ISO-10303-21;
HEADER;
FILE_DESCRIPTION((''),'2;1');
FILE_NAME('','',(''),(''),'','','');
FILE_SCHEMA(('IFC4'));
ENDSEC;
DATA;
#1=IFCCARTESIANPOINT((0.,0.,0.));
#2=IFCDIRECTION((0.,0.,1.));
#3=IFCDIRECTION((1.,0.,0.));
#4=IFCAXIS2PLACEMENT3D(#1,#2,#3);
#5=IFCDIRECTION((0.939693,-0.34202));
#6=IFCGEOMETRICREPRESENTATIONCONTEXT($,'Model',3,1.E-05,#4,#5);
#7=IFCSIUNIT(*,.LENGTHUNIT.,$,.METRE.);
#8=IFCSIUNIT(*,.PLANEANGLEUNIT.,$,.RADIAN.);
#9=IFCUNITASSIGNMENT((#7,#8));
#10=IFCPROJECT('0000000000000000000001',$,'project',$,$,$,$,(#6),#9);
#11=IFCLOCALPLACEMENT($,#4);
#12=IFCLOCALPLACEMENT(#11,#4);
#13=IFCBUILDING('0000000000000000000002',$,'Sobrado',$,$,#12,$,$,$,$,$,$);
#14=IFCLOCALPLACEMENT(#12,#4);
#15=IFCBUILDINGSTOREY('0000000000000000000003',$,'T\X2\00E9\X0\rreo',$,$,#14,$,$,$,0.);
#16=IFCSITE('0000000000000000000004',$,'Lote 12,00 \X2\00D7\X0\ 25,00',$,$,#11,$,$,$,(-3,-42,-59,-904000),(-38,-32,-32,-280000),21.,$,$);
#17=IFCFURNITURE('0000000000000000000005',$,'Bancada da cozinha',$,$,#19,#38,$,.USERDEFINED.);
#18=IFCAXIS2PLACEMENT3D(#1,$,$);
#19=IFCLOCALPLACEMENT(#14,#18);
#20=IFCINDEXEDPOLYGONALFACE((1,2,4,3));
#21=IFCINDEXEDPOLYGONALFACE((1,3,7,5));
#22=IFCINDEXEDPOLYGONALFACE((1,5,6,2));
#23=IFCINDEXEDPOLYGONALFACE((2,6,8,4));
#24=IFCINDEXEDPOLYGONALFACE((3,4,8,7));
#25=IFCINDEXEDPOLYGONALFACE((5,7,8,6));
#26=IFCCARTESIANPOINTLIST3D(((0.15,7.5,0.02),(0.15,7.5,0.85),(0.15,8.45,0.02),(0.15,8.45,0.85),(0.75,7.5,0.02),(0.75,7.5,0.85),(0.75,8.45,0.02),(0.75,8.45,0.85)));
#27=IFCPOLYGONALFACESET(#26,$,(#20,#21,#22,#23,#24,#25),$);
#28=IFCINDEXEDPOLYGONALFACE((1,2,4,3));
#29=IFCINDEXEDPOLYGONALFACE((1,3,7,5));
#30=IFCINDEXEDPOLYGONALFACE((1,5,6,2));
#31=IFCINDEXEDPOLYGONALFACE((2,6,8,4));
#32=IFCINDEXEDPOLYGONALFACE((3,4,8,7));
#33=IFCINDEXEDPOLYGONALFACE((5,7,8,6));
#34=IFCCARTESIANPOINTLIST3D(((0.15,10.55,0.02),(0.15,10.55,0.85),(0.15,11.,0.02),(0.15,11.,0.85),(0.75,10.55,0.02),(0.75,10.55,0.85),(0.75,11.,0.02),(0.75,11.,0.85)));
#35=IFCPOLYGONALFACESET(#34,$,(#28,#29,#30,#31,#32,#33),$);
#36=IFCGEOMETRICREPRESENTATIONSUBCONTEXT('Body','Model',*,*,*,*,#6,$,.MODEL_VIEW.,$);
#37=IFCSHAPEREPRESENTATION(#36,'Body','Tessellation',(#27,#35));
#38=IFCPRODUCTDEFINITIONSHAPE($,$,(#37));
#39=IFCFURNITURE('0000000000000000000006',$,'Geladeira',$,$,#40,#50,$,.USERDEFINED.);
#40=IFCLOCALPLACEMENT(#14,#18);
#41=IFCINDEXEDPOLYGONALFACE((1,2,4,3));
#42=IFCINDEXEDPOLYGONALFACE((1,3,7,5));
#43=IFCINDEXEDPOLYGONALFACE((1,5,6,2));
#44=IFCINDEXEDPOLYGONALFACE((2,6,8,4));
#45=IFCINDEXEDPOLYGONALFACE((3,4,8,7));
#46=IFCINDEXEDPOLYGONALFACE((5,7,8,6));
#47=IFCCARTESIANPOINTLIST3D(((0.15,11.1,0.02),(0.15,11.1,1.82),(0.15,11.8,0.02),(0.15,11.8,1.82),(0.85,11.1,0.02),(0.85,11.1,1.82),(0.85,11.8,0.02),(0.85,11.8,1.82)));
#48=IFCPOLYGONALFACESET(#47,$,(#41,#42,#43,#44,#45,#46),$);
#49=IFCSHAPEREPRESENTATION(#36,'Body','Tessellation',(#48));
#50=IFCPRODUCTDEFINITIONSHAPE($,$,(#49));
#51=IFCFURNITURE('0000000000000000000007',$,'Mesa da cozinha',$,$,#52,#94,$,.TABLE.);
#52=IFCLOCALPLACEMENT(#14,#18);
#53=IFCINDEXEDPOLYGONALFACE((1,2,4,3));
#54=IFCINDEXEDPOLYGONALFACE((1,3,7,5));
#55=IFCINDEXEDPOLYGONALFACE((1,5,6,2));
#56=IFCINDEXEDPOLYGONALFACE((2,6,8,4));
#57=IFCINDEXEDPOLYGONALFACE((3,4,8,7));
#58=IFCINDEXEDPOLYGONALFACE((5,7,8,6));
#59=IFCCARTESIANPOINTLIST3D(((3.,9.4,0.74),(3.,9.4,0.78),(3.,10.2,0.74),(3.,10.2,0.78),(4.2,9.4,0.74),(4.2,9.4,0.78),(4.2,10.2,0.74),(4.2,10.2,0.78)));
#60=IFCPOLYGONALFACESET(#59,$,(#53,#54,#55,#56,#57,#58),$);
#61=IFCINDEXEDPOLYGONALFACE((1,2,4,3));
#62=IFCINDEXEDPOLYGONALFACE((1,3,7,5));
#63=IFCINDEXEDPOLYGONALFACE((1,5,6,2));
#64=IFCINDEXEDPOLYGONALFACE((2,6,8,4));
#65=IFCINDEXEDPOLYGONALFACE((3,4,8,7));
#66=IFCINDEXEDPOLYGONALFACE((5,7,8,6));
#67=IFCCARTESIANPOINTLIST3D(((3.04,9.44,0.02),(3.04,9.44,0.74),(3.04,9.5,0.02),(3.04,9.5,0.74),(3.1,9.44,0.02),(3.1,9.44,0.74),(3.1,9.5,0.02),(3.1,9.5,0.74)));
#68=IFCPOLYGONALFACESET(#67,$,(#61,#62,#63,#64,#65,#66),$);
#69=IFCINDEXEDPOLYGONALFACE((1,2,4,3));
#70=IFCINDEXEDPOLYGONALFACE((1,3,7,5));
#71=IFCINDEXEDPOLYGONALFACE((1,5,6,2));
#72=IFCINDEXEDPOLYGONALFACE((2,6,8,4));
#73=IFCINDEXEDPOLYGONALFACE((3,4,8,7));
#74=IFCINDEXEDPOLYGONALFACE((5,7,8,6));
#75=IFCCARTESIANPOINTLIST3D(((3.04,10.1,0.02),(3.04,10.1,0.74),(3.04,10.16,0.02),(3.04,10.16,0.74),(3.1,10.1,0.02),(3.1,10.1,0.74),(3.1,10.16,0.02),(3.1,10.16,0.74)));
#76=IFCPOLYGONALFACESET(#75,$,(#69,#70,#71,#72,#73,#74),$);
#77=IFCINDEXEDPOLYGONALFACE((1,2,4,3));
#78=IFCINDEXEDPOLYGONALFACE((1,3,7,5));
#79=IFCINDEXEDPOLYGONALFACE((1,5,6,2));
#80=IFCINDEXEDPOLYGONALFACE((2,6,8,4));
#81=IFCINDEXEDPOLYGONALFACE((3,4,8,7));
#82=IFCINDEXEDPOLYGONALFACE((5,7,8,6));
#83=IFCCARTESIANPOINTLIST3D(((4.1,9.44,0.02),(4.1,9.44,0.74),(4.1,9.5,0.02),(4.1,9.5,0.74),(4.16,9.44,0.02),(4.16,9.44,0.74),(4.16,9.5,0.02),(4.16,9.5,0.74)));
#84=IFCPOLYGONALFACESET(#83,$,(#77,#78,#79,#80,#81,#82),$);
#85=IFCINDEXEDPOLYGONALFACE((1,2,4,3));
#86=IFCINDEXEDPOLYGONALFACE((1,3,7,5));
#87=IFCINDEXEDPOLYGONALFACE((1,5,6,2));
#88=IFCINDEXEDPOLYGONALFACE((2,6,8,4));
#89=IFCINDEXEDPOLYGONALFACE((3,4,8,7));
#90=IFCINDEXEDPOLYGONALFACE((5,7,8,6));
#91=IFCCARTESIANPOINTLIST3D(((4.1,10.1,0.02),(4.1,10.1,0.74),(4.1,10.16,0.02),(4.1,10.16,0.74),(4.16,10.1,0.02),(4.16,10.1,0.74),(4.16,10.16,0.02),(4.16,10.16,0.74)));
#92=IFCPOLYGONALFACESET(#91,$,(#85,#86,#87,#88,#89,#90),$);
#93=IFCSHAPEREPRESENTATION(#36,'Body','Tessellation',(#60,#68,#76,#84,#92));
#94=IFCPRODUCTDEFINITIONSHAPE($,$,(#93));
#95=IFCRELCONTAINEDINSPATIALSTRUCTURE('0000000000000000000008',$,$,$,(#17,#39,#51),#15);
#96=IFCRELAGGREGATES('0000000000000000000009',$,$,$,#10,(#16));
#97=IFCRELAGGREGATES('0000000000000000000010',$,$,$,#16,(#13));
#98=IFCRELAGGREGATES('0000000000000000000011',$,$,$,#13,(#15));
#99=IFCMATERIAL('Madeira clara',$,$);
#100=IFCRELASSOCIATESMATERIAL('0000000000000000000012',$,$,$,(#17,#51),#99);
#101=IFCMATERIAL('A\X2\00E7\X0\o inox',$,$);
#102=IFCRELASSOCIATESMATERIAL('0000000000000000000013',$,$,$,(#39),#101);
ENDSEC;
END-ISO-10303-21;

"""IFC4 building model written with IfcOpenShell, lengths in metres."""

from ifc_helpers import new_model, si_unit, direction, frame, origin_with_axes, place, context, subcontext, project, spatial, line, indexed_curve, outline, extrude, material, element, save


model = new_model("IFC4")

# Units and contexts
model_context = context("Model", 3, precision=1e-05, world=origin_with_axes(), true_north=direction((0.939693, -0.34202)))
body_context = subcontext(model_context, "Body", "Model", "MODEL_VIEW")
ifc_project = project(units=[si_unit("LENGTHUNIT", "METRE"), si_unit("PLANEANGLEUNIT", "RADIAN")], contexts=[model_context])

# Site, building, storey
site_placement = place(None, origin_with_axes())
site = spatial("IfcSite", under=ifc_project, at=site_placement, Name="Lote 12,00 × 25,00", RefLatitude=(-3, -42, -59, -904000), RefLongitude=(-38, -32, -32, -280000), RefElevation=21.0)
building_placement = place(site_placement, origin_with_axes())
building = spatial("IfcBuilding", under=site, at=building_placement, Name="Sobrado")
storey_placement = place(building_placement, origin_with_axes())
storey = spatial("IfcBuildingStorey", under=building, at=storey_placement, Name="Térreo", Elevation=0.0)

# Furniture
ifc_material_1 = material(Name="Madeira clara")
furniture_1_placement = place(storey_placement, origin_with_axes())
element("IfcFurniture", 1, at=furniture_1_placement, inside=storey, material=ifc_material_1, Name="Bancada da cozinha", PredefinedType="USERDEFINED", context=body_context, shape_type="SweptSolid", body=[
    extrude(outline(indexed_curve([(0.15, 7.5), (0.75, 7.5), (0.75, 8.45), (0.15, 8.45)], segments=[line(1, 2, 3, 4, 1)])), frame((0.0, 0.0, 0.02), z_axis=(0.0, 0.0, 1.0), x_axis=(1.0, 0.0, 0.0)), (0.0, 0.0, 1.0), 0.83),
    extrude(outline(indexed_curve([(0.15, 10.55), (0.75, 10.55), (0.75, 11.0), (0.15, 11.0)], segments=[line(1, 2, 3, 4, 1)])), frame((0.0, 0.0, 0.02), z_axis=(0.0, 0.0, 1.0), x_axis=(1.0, 0.0, 0.0)), (0.0, 0.0, 1.0), 0.83),
])
ifc_material_2 = material(Name="Aço inox")
furniture_2_placement = place(storey_placement, origin_with_axes())
element("IfcFurniture", 2, at=furniture_2_placement, inside=storey, material=ifc_material_2, Name="Geladeira", PredefinedType="USERDEFINED", context=body_context, shape_type="SweptSolid", body=[
    extrude(outline(indexed_curve([(0.15, 11.1), (0.85, 11.1), (0.85, 11.8), (0.15, 11.8)], segments=[line(1, 2, 3, 4, 1)])), frame((0.0, 0.0, 0.02), z_axis=(0.0, 0.0, 1.0), x_axis=(1.0, 0.0, 0.0)), (0.0, 0.0, 1.0), 1.8),
])
furniture_3_placement = place(storey_placement, origin_with_axes())
element("IfcFurniture", 3, at=furniture_3_placement, inside=storey, material=ifc_material_1, Name="Mesa da cozinha", PredefinedType="TABLE", context=body_context, shape_type="SweptSolid", body=[
    extrude(outline(indexed_curve([(3.0, 9.4), (4.2, 9.4), (4.2, 10.2), (3.0, 10.2)], segments=[line(1, 2, 3, 4, 1)])), frame((0.0, 0.0, 0.74), z_axis=(0.0, 0.0, 1.0), x_axis=(1.0, 0.0, 0.0)), (0.0, 0.0, 1.0), 0.04),
    extrude(outline(indexed_curve([(3.04, 9.44), (3.1, 9.44), (3.1, 9.5), (3.04, 9.5)], segments=[line(1, 2, 3, 4, 1)])), frame((0.0, 0.0, 0.02), z_axis=(0.0, 0.0, 1.0), x_axis=(1.0, 0.0, 0.0)), (0.0, 0.0, 1.0), 0.72),
    extrude(outline(indexed_curve([(3.04, 10.1), (3.1, 10.1), (3.1, 10.16), (3.04, 10.16)], segments=[line(1, 2, 3, 4, 1)])), frame((0.0, 0.0, 0.02), z_axis=(0.0, 0.0, 1.0), x_axis=(1.0, 0.0, 0.0)), (0.0, 0.0, 1.0), 0.72),
    extrude(outline(indexed_curve([(4.1, 9.44), (4.16, 9.44), (4.16, 9.5), (4.1, 9.5)], segments=[line(1, 2, 3, 4, 1)])), frame((0.0, 0.0, 0.02), z_axis=(0.0, 0.0, 1.0), x_axis=(1.0, 0.0, 0.0)), (0.0, 0.0, 1.0), 0.72),
    extrude(outline(indexed_curve([(4.1, 10.1), (4.16, 10.1), (4.16, 10.16), (4.1, 10.16)], segments=[line(1, 2, 3, 4, 1)])), frame((0.0, 0.0, 0.02), z_axis=(0.0, 0.0, 1.0), x_axis=(1.0, 0.0, 0.0)), (0.0, 0.0, 1.0), 0.72),
])

save(model, "model.ifc")
